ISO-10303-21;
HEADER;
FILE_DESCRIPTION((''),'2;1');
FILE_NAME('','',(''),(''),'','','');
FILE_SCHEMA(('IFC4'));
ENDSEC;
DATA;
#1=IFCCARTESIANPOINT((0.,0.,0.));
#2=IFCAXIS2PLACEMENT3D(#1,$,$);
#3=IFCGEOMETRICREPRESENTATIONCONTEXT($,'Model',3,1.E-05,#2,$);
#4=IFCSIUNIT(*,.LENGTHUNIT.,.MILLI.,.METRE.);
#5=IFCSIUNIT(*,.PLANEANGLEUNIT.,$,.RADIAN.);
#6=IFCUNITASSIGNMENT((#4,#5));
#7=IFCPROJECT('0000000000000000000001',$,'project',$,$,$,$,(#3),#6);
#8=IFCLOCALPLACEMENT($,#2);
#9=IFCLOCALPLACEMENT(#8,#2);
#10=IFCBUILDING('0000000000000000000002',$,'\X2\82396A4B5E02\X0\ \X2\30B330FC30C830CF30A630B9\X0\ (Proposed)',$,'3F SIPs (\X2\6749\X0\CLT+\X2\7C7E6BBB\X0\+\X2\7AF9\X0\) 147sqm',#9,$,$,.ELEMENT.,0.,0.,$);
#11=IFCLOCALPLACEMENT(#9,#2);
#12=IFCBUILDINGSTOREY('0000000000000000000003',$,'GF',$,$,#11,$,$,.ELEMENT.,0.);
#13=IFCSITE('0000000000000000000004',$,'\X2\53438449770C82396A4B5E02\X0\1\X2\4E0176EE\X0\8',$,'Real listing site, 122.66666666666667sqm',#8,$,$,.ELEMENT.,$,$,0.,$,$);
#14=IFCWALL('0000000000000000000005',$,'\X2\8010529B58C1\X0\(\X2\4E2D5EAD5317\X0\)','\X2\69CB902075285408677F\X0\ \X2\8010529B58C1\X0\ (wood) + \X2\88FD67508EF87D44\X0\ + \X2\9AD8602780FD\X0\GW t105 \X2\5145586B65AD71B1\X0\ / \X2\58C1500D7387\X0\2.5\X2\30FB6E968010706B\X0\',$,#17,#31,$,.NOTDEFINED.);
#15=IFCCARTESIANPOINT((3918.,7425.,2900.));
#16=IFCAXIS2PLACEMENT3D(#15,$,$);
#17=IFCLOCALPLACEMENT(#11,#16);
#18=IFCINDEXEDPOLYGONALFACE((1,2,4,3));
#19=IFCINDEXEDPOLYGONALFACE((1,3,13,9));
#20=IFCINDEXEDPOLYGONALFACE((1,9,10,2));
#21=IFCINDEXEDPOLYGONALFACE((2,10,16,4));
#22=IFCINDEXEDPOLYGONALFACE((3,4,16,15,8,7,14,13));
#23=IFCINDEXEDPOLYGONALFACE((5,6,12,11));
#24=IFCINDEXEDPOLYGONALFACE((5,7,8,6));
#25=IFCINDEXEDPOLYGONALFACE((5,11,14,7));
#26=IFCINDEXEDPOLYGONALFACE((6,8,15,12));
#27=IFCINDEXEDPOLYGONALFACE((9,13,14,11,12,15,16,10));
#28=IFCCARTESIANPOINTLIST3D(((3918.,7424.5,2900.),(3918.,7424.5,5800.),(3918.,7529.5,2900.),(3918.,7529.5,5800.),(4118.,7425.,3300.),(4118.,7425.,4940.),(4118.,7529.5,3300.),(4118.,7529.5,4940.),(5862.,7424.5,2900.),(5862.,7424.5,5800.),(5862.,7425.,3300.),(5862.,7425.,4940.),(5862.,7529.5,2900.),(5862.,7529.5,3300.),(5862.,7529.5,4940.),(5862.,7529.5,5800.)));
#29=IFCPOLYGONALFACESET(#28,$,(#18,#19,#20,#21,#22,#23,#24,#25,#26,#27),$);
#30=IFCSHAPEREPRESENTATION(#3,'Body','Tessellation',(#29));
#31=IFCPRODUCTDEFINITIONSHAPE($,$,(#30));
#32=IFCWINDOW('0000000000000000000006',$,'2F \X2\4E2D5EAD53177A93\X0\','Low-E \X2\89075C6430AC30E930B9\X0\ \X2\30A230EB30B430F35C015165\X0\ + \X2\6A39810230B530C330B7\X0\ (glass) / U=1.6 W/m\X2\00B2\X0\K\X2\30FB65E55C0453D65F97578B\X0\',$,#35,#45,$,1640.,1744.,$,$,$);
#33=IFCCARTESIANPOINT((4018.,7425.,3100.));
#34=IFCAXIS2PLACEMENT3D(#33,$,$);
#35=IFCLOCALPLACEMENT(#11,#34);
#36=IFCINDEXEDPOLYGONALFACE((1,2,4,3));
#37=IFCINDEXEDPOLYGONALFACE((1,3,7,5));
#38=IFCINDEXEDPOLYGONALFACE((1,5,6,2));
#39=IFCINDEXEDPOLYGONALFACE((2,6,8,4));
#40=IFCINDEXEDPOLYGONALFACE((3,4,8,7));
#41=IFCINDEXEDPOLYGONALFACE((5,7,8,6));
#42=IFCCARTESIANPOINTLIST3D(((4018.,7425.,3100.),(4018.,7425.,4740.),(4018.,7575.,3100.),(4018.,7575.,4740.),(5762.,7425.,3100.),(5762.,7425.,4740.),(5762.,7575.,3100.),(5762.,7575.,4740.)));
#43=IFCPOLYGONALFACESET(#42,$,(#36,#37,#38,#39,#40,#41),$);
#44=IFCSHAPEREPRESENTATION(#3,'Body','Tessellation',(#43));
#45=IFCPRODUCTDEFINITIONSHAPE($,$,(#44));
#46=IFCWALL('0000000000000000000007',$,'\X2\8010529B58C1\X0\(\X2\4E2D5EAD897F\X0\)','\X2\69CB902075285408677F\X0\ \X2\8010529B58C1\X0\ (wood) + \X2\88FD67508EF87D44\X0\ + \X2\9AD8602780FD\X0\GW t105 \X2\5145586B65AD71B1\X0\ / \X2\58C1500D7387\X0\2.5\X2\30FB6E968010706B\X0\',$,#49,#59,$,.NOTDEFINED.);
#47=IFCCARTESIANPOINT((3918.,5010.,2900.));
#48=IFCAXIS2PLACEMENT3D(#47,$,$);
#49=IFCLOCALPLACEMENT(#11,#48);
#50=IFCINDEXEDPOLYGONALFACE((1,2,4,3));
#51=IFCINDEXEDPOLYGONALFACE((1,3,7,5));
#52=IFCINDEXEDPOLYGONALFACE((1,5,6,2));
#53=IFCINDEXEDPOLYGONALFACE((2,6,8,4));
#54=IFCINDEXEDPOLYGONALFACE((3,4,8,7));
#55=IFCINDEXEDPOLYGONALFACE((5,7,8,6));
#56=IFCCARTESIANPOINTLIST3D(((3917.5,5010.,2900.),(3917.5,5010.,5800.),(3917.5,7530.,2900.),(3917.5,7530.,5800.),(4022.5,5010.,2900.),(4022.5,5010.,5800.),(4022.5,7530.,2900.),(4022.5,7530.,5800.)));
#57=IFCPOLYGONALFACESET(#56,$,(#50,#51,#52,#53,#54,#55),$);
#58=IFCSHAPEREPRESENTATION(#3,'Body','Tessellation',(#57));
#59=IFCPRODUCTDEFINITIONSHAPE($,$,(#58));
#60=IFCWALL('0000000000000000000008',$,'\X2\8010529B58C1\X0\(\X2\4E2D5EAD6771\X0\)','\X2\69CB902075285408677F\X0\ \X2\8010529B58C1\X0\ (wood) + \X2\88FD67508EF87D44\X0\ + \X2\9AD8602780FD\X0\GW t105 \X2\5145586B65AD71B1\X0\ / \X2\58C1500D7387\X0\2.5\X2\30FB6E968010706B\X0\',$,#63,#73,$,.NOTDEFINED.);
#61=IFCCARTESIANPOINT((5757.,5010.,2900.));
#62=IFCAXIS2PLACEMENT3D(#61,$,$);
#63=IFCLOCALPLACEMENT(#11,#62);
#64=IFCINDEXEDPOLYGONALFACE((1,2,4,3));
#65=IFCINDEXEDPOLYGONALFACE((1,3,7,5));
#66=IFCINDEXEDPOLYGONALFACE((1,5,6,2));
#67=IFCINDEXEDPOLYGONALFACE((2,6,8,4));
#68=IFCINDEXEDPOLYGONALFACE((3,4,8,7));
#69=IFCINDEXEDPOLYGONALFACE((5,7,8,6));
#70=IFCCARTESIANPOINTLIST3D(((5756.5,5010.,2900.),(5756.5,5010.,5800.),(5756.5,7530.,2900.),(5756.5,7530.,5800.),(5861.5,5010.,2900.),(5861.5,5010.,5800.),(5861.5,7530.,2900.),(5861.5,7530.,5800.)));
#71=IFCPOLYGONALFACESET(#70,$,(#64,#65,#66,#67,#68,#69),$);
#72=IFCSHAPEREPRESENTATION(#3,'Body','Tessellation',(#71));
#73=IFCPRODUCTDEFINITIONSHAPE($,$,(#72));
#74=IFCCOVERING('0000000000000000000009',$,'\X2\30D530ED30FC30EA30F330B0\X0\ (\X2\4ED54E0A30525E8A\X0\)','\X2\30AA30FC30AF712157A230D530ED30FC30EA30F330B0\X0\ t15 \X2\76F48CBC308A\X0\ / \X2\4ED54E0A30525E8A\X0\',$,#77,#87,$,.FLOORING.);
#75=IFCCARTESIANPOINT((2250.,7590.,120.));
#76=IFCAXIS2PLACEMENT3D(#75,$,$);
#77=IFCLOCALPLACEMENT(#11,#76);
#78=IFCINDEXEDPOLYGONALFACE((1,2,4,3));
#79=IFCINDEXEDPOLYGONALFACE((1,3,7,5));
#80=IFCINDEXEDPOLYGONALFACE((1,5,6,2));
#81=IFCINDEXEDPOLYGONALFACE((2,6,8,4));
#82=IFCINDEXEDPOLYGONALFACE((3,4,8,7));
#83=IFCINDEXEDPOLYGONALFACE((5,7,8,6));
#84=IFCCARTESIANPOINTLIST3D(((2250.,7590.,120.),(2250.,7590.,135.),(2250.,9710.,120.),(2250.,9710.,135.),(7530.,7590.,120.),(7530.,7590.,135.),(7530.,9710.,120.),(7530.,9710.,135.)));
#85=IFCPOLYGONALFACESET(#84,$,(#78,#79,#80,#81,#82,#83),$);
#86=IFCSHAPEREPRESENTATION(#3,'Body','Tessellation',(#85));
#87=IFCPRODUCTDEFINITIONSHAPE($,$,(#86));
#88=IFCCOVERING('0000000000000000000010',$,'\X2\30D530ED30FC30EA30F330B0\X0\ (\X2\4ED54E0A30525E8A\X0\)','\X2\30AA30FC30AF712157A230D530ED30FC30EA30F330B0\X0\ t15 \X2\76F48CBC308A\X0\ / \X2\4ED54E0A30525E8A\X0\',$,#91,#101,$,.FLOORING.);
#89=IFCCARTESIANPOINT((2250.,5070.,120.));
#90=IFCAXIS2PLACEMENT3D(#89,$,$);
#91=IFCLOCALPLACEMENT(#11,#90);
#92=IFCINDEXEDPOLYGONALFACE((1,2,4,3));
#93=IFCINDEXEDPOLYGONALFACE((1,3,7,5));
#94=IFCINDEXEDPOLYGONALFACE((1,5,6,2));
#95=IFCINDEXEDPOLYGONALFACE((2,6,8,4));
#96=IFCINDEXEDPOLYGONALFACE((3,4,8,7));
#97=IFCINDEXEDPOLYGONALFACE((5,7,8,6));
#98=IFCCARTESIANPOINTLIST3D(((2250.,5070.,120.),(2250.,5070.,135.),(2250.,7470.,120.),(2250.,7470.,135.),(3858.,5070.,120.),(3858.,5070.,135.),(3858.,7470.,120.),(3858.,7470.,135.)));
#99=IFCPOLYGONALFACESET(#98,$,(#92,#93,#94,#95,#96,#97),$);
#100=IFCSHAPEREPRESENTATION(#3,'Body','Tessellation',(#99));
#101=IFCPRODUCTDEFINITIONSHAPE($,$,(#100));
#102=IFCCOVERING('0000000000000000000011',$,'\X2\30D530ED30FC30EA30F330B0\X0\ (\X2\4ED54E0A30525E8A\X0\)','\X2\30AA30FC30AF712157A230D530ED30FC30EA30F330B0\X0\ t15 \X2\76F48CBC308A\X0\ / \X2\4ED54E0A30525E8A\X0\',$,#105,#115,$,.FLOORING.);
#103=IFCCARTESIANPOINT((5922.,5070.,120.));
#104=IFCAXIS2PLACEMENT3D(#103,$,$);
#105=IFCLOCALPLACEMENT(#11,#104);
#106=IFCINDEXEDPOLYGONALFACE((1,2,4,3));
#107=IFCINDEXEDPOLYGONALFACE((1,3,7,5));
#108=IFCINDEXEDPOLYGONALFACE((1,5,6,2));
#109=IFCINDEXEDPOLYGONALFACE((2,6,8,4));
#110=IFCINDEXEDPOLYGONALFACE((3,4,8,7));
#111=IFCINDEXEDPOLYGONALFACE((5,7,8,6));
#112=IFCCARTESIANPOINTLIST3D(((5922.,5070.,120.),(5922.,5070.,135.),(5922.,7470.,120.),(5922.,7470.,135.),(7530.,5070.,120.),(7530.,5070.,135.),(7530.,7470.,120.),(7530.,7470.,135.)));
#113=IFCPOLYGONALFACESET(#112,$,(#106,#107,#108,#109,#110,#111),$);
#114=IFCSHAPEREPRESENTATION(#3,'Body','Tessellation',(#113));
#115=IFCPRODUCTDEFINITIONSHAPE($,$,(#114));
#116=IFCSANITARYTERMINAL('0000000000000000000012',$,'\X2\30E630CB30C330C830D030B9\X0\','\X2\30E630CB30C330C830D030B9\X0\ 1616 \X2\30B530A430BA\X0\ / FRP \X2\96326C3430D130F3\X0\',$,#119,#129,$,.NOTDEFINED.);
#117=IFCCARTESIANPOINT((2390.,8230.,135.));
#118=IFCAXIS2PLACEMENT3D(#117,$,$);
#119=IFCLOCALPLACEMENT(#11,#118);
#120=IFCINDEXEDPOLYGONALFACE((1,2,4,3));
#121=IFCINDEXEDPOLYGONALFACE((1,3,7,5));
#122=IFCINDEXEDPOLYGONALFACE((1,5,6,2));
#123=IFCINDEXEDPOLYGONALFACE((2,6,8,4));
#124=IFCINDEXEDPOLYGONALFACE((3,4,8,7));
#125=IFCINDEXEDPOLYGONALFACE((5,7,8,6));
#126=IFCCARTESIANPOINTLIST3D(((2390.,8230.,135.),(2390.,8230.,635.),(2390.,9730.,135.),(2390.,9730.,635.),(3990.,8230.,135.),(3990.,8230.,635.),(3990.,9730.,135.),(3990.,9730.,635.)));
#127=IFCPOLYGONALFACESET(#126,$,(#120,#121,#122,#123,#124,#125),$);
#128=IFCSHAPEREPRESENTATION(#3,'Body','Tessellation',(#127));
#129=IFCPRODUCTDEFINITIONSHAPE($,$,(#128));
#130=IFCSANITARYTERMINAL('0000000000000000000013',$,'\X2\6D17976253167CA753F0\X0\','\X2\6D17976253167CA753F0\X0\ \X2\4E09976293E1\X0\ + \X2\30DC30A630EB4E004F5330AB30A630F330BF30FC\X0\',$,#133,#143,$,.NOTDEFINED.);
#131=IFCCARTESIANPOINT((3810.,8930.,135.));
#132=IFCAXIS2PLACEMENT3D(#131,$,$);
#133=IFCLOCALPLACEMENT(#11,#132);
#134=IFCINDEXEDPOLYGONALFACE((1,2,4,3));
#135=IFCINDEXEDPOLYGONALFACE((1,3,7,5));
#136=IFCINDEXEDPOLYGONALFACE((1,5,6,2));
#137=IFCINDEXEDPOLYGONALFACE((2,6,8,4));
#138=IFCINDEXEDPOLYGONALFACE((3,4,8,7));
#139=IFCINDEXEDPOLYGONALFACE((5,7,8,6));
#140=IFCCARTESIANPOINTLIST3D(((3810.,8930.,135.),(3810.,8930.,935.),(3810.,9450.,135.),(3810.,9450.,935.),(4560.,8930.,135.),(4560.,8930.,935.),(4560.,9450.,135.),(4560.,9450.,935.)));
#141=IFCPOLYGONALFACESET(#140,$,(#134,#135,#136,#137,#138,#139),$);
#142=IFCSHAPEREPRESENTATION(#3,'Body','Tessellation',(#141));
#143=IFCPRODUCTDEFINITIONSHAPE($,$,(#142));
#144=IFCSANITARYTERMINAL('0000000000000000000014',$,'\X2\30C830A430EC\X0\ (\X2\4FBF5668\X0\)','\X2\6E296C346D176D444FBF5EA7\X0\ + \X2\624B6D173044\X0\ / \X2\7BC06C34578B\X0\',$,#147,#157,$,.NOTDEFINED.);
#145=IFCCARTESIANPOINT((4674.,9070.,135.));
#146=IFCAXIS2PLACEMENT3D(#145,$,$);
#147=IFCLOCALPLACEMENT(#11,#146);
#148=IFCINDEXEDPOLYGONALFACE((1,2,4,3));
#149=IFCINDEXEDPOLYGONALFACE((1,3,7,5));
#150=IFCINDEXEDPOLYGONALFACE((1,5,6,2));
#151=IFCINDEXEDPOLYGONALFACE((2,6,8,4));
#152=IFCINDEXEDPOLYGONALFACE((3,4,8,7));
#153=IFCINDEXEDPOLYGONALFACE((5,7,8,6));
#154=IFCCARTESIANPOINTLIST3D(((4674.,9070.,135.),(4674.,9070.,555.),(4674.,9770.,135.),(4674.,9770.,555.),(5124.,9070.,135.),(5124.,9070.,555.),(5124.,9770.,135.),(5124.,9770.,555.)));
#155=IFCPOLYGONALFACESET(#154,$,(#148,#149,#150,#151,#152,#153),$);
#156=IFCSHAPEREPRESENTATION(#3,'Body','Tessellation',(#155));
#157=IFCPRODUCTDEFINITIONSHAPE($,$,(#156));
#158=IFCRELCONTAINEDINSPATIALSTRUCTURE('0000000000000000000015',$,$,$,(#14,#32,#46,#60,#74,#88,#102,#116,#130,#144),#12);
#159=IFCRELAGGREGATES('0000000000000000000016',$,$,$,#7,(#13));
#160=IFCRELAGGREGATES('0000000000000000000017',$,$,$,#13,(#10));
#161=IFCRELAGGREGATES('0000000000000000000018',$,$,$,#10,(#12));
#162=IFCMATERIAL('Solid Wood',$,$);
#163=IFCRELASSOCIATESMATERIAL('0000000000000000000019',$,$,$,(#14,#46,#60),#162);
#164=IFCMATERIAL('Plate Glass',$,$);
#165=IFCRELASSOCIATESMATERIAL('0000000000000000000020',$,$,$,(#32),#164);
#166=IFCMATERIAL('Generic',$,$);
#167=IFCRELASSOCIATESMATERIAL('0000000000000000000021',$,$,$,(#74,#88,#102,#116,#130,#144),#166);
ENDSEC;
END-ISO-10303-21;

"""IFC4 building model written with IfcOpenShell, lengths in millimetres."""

from ifc_helpers import new_model, si_unit, frame, frame_2d, origin, place, context, project, spatial, rectangle, extrude, material, element, fill, save


model = new_model("IFC4")

# Units and contexts
model_context = context("Model", 3, precision=1e-05, world=origin())
ifc_project = project(units=[si_unit("LENGTHUNIT", "METRE", prefix="MILLI"), si_unit("PLANEANGLEUNIT", "RADIAN")], contexts=[model_context])

# Site, building, storey
site_placement = place(None, origin())
site = spatial("IfcSite", under=ifc_project, at=site_placement, Name="千葉県船橋市1丁目8", ObjectType="Real listing site, 122.66666666666667sqm", CompositionType="ELEMENT", RefElevation=0.0)
building_placement = place(site_placement, origin())
building = spatial("IfcBuilding", under=site, at=building_placement, Name="船橋市 コートハウス (Proposed)", ObjectType="3F SIPs (杉CLT+籾殻+竹) 147sqm", CompositionType="ELEMENT", ElevationOfRefHeight=0.0, ElevationOfTerrain=0.0)
storey_placement = place(building_placement, origin())
storey = spatial("IfcBuildingStorey", under=building, at=storey_placement, Name="GF", CompositionType="ELEMENT", Elevation=0.0)

# Shared definitions
ifc_material_1 = material(Name="Solid Wood")

# Shared definitions
ifc_material_2 = material(Name="Plate Glass")

# Wall, opening, window
wall_1_placement = place(storey_placement, frame((3918.0, 7425.0, 2900.0)))
wall_1 = element("IfcWall", 1, at=wall_1_placement, inside=storey, material=ifc_material_1, Name="耐力壁(中庭北)", Description="構造用合板 耐力壁 (wood) + 製材軸組 + 高性能GW t105 充填断熱 / 壁倍率2.5・準耐火", PredefinedType="NOTDEFINED", context=model_context, shape_type="SweptSolid", body=[
    extrude(rectangle(XDim=1944.0, YDim=105.0, at=frame_2d((972.0, 52.0))), frame((3918.0, 7425.0, 2900.0)), (0.0, 0.0, 1.0), 2900.0),
])
opening_1_placement = place(storey_placement, frame((4018.0, 7425.0, 3100.0)))
opening_1 = element("IfcOpeningElement", 2, at=opening_1_placement, cuts=wall_1, PredefinedType="NOTDEFINED", context=model_context, shape_type="SweptSolid", body=[
    extrude(rectangle(XDim=1744.0, YDim=150.0, at=frame_2d((872.0, 75.0))), frame((4018.0, 7425.0, 3100.0)), (0.0, 0.0, 1.0), 1640.0),
])
window_1_placement = place(storey_placement, frame((4018.0, 7425.0, 3100.0)))
window_1 = element("IfcWindow", 3, at=window_1_placement, inside=storey, material=ifc_material_2, Name="2F 中庭北窓", Description="Low-E 複層ガラス アルゴン封入 + 樹脂サッシ (glass) / U=1.6 W/m²K・日射取得型", OverallHeight=1640.0, OverallWidth=1744.0, context=model_context, shape_type="SweptSolid", body=[
    extrude(rectangle(XDim=1744.0, YDim=150.0, at=frame_2d((872.0, 75.0))), frame((4018.0, 7425.0, 3100.0)), (0.0, 0.0, 1.0), 1640.0),
])
fill(opening_1, window_1)

# Walls
wall_2_placement = place(storey_placement, frame((3918.0, 5010.0, 2900.0)))
element("IfcWall", 4, at=wall_2_placement, inside=storey, material=ifc_material_1, Name="耐力壁(中庭西)", Description="構造用合板 耐力壁 (wood) + 製材軸組 + 高性能GW t105 充填断熱 / 壁倍率2.5・準耐火", PredefinedType="NOTDEFINED", context=model_context, shape_type="SweptSolid", body=[
    extrude(rectangle(XDim=105.0, YDim=2520.0, at=frame_2d((52.0, 1260.0))), frame((3918.0, 5010.0, 2900.0)), (0.0, 0.0, 1.0), 2900.0),
])
wall_3_placement = place(storey_placement, frame((5757.0, 5010.0, 2900.0)))
element("IfcWall", 5, at=wall_3_placement, inside=storey, material=ifc_material_1, Name="耐力壁(中庭東)", Description="構造用合板 耐力壁 (wood) + 製材軸組 + 高性能GW t105 充填断熱 / 壁倍率2.5・準耐火", PredefinedType="NOTDEFINED", context=model_context, shape_type="SweptSolid", body=[
    extrude(rectangle(XDim=105.0, YDim=2520.0, at=frame_2d((52.0, 1260.0))), frame((5757.0, 5010.0, 2900.0)), (0.0, 0.0, 1.0), 2900.0),
])

# Coverings
ifc_material_3 = material(Name="Generic")
covering_1_placement = place(storey_placement, frame((2250.0, 7590.0, 120.0)))
element("IfcCovering", 6, at=covering_1_placement, inside=storey, material=ifc_material_3, Name="フローリング (仕上げ床)", Description="オーク無垢フローリング t15 直貼り / 仕上げ床", PredefinedType="FLOORING", context=model_context, shape_type="SweptSolid", body=[
    extrude(rectangle(XDim=5280.0, YDim=2120.0, at=frame_2d((2640.0, 1060.0))), frame((2250.0, 7590.0, 120.0)), (0.0, 0.0, 1.0), 15.0),
])
covering_2_placement = place(storey_placement, frame((2250.0, 5070.0, 120.0)))
element("IfcCovering", 7, at=covering_2_placement, inside=storey, material=ifc_material_3, Name="フローリング (仕上げ床)", Description="オーク無垢フローリング t15 直貼り / 仕上げ床", PredefinedType="FLOORING", context=model_context, shape_type="SweptSolid", body=[
    extrude(rectangle(XDim=1608.0, YDim=2400.0, at=frame_2d((804.0, 1200.0))), frame((2250.0, 5070.0, 120.0)), (0.0, 0.0, 1.0), 15.0),
])
covering_3_placement = place(storey_placement, frame((5922.0, 5070.0, 120.0)))
element("IfcCovering", 8, at=covering_3_placement, inside=storey, material=ifc_material_3, Name="フローリング (仕上げ床)", Description="オーク無垢フローリング t15 直貼り / 仕上げ床", PredefinedType="FLOORING", context=model_context, shape_type="SweptSolid", body=[
    extrude(rectangle(XDim=1608.0, YDim=2400.0, at=frame_2d((804.0, 1200.0))), frame((5922.0, 5070.0, 120.0)), (0.0, 0.0, 1.0), 15.0),
])

# Sanitary terminals
sanitary_terminal_1_placement = place(storey_placement, frame((2390.0, 8230.0, 135.0)))
element("IfcSanitaryTerminal", 9, at=sanitary_terminal_1_placement, inside=storey, material=ifc_material_3, Name="ユニットバス", Description="ユニットバス 1616 サイズ / FRP 防水パン", PredefinedType="NOTDEFINED", context=model_context, shape_type="SweptSolid", body=[
    extrude(rectangle(XDim=1600.0, YDim=1500.0, at=frame_2d((800.0, 750.0))), frame((2390.0, 8230.0, 135.0)), (0.0, 0.0, 1.0), 500.0),
])
sanitary_terminal_2_placement = place(storey_placement, frame((3810.0, 8930.0, 135.0)))
element("IfcSanitaryTerminal", 10, at=sanitary_terminal_2_placement, inside=storey, material=ifc_material_3, Name="洗面化粧台", Description="洗面化粧台 三面鏡 + ボウル一体カウンター", PredefinedType="NOTDEFINED", context=model_context, shape_type="SweptSolid", body=[
    extrude(rectangle(XDim=750.0, YDim=520.0, at=frame_2d((375.0, 260.0))), frame((3810.0, 8930.0, 135.0)), (0.0, 0.0, 1.0), 800.0),
])
sanitary_terminal_3_placement = place(storey_placement, frame((4674.0, 9070.0, 135.0)))
element("IfcSanitaryTerminal", 11, at=sanitary_terminal_3_placement, inside=storey, material=ifc_material_3, Name="トイレ (便器)", Description="温水洗浄便座 + 手洗い / 節水型", PredefinedType="NOTDEFINED", context=model_context, shape_type="SweptSolid", body=[
    extrude(rectangle(XDim=450.0, YDim=700.0, at=frame_2d((225.0, 350.0))), frame((4674.0, 9070.0, 135.0)), (0.0, 0.0, 1.0), 420.0),
])

save(model, "model.ifc")
